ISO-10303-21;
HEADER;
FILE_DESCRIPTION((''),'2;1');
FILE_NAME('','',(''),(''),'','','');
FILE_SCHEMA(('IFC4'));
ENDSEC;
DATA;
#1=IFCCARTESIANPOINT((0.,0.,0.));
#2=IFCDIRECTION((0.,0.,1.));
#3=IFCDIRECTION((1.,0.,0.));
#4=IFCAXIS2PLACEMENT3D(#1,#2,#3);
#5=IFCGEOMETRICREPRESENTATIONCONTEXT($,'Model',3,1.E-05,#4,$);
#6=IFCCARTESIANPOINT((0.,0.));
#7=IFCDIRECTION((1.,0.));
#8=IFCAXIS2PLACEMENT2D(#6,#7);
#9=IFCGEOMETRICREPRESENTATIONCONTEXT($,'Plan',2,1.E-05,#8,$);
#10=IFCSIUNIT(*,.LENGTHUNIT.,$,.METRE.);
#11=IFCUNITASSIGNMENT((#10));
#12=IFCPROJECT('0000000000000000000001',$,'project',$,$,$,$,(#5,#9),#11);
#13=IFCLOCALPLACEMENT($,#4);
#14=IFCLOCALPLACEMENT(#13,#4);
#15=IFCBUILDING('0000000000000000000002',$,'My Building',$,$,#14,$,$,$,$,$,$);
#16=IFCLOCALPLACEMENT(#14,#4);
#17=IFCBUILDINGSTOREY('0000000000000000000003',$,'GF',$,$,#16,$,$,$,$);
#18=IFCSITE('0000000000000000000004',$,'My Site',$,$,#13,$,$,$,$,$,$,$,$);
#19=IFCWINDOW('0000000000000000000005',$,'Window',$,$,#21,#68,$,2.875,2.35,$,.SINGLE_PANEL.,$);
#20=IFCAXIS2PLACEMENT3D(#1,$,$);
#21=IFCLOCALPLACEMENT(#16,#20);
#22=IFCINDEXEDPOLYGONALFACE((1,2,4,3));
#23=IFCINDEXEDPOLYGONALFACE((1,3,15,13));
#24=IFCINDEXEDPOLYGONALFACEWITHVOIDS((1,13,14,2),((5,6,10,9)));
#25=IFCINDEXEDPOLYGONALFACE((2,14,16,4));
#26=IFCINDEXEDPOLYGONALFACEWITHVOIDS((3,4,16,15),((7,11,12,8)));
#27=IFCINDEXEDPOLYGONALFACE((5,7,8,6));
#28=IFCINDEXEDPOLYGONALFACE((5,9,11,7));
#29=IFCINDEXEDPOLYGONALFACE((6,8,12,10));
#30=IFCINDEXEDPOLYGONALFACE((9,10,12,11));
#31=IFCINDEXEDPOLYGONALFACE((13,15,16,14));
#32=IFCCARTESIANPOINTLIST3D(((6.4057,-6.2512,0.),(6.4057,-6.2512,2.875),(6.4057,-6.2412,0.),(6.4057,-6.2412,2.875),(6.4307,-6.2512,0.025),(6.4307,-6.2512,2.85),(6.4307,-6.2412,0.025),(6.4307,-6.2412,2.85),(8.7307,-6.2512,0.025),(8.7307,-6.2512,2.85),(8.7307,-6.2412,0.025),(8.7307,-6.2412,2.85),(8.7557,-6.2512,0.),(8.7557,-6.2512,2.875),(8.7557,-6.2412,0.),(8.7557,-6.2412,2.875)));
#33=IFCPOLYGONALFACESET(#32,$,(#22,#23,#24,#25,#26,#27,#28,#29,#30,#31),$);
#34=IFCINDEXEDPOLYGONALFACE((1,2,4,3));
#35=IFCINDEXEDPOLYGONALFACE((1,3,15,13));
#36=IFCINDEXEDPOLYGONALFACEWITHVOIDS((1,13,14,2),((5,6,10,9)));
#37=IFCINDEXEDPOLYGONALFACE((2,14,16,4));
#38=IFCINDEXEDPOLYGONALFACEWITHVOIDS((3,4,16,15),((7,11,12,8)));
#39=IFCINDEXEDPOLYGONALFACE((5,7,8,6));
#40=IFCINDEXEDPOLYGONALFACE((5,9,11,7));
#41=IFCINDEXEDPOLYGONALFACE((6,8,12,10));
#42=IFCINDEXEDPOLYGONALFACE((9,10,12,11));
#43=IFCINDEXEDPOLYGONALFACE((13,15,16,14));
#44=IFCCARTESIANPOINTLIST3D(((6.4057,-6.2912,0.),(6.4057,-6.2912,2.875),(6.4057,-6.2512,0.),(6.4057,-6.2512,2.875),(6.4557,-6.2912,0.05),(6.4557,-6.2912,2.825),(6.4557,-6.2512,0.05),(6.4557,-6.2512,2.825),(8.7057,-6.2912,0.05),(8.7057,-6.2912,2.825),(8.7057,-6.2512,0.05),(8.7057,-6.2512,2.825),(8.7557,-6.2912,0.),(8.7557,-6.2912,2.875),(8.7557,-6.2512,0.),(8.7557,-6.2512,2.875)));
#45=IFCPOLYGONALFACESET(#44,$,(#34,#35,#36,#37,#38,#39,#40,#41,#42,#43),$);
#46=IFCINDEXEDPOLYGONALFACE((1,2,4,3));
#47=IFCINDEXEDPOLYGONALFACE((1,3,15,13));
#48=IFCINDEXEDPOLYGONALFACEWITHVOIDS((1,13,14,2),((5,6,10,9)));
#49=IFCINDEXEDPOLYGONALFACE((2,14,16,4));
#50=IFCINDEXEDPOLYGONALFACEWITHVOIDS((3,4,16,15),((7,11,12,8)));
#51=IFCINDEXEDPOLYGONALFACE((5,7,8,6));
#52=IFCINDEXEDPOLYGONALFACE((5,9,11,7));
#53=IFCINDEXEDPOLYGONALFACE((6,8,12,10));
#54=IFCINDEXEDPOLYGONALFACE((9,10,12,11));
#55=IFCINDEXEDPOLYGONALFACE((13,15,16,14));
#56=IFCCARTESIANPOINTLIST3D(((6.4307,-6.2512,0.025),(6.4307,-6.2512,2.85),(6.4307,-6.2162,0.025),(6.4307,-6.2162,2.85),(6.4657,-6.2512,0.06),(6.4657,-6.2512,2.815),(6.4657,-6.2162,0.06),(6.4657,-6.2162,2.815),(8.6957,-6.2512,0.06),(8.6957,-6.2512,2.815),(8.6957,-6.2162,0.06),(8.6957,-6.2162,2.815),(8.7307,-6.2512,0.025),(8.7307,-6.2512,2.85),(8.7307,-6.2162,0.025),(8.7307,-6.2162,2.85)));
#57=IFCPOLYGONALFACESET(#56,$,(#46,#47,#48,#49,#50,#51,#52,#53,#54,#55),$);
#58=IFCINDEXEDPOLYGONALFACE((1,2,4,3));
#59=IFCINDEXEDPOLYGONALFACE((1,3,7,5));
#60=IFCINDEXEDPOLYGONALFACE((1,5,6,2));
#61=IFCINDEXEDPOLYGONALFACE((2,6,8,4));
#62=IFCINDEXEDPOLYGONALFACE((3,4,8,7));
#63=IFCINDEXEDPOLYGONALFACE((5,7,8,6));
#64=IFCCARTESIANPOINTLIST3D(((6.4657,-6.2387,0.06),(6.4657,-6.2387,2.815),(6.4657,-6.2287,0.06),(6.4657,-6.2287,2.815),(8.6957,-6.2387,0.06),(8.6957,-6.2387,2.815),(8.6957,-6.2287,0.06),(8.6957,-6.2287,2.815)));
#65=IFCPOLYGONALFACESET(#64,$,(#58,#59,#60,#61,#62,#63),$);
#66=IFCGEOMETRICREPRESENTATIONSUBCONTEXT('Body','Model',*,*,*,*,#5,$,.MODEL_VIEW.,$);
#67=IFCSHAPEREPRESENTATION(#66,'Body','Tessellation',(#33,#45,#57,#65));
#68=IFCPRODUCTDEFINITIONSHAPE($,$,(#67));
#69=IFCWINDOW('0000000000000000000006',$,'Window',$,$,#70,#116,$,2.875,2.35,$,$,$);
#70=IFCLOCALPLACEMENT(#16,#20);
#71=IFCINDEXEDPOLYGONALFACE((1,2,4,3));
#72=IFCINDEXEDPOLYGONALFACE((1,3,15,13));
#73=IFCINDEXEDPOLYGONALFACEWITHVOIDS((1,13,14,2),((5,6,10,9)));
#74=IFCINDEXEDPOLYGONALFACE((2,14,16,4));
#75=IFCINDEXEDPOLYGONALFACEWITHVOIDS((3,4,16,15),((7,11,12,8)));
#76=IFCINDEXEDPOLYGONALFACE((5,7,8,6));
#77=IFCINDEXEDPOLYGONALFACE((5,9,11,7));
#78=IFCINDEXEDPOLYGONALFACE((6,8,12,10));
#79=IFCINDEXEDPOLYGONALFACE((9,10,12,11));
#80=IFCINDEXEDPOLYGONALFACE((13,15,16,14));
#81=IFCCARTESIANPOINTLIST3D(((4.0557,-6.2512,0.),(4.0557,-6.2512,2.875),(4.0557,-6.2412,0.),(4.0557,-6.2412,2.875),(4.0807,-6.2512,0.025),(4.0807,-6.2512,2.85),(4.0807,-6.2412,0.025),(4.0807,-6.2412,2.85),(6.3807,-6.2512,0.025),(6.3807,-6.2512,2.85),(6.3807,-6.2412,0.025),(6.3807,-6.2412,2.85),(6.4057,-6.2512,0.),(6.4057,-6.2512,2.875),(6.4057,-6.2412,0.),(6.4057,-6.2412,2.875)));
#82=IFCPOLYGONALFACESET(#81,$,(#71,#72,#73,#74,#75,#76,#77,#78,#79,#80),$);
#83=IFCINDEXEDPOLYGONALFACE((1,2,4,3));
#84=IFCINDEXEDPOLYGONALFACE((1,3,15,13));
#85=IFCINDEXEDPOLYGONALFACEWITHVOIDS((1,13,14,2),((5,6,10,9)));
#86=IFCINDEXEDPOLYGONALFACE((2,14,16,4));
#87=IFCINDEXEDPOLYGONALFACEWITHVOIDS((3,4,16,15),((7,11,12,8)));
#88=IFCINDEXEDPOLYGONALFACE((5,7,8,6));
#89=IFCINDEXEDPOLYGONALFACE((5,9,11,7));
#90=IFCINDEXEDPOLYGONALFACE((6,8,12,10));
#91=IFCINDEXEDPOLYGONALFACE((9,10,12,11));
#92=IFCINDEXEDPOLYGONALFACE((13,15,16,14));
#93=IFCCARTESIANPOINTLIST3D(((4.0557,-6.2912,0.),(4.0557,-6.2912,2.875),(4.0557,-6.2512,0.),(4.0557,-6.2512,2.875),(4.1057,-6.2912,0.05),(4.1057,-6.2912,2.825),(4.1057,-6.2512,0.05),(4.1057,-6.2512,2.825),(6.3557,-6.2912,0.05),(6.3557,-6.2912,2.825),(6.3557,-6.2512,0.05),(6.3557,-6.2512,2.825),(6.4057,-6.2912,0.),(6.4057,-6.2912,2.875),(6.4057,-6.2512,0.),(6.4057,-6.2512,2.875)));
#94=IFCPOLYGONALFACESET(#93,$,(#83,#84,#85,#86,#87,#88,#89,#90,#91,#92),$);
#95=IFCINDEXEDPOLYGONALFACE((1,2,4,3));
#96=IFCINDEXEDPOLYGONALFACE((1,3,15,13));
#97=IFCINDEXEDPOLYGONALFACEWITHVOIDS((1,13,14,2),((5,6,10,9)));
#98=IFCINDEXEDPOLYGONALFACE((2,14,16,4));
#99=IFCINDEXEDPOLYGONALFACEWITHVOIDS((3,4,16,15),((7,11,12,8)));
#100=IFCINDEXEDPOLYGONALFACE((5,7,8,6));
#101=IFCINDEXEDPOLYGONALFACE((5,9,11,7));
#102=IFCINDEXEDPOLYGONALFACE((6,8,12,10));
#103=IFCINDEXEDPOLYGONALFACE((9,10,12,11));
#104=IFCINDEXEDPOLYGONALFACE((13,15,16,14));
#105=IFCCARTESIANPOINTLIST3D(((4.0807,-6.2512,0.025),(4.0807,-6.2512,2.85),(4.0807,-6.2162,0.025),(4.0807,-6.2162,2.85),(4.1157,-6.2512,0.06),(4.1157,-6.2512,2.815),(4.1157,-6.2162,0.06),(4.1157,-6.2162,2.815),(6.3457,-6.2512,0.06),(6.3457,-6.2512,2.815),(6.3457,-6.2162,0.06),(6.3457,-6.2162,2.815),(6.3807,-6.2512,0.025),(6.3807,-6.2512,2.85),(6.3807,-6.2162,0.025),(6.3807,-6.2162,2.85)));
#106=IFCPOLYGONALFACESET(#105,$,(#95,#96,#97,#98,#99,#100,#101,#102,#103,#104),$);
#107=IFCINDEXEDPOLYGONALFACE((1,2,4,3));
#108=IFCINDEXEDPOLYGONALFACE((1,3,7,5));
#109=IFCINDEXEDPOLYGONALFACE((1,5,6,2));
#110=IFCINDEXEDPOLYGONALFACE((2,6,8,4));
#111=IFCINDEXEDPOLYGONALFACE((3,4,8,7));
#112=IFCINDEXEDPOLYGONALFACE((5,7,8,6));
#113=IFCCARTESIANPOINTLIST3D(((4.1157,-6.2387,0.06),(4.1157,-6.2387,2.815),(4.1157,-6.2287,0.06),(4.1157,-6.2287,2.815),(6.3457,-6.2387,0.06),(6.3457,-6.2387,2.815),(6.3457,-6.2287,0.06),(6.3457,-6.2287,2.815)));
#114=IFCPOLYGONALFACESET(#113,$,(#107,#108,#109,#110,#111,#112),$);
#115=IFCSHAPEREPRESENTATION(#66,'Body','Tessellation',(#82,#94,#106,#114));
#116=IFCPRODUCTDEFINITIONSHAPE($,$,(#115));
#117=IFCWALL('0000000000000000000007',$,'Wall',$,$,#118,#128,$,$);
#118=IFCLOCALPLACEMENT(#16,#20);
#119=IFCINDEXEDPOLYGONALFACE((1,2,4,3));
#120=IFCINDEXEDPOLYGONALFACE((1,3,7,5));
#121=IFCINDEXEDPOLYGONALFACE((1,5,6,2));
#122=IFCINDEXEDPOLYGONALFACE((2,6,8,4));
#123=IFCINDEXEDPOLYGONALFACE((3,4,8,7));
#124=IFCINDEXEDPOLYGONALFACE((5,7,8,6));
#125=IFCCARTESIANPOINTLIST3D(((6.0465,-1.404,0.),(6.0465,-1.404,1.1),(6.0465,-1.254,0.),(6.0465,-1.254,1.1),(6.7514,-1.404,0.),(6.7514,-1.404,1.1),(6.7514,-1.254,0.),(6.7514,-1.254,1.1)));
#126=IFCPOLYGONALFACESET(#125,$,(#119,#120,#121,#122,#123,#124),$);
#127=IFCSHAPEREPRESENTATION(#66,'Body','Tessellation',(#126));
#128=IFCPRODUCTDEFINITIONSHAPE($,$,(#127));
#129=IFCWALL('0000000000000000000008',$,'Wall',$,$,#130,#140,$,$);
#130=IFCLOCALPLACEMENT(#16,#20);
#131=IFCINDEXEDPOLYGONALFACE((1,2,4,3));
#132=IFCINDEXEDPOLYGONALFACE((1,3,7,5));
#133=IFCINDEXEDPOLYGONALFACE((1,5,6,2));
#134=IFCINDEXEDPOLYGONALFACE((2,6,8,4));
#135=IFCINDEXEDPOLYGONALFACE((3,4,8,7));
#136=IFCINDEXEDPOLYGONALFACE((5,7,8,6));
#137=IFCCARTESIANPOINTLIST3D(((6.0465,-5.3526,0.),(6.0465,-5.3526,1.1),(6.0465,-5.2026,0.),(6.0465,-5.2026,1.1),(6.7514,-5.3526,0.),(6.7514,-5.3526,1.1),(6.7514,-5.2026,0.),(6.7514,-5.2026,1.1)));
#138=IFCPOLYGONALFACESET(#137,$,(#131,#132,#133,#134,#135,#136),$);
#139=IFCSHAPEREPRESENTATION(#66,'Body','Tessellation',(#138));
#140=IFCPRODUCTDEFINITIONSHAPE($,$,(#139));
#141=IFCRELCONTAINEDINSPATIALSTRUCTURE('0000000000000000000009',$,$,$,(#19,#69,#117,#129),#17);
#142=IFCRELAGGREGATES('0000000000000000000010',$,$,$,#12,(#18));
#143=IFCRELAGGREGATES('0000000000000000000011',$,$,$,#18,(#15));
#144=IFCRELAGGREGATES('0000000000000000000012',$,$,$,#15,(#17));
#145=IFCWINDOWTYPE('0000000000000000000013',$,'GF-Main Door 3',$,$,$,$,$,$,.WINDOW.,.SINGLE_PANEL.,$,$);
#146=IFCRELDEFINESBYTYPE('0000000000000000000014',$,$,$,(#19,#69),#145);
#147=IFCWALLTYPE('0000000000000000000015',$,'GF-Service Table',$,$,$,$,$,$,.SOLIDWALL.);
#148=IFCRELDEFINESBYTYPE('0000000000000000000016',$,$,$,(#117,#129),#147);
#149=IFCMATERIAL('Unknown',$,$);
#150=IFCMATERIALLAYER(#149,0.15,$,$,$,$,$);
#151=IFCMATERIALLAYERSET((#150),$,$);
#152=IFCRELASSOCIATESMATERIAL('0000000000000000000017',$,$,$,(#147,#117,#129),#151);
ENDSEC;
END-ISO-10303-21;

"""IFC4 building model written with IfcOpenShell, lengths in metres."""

from ifc_helpers import new_model, entity, si_unit, frame, origin_with_axes, origin_2d_with_axis, place, context, subcontext, project, spatial, line, indexed_curve, outline, extrude, shape, source, transform, mapped, material, layer, layer_set, layer_usage, type_object, type_shapes, element, save


model = new_model("IFC4")

# Units and contexts
model_context = context("Model", 3, precision=1e-05, world=origin_with_axes())
plan_context = context("Plan", 2, precision=1e-05, world=origin_2d_with_axis())
body_context_1 = subcontext(model_context, "Body", "Model", "MODEL_VIEW")
body_context_2 = subcontext(plan_context, "Body", "Plan", "PLAN_VIEW")
ifc_project = project(units=[si_unit("LENGTHUNIT", "METRE")], contexts=[model_context, plan_context])

# Site, building, storey
site_placement = place(None, origin_with_axes())
site = spatial("IfcSite", under=ifc_project, at=site_placement, Name="My Site")
building_placement = place(site_placement, origin_with_axes())
building = spatial("IfcBuilding", under=site, at=building_placement, Name="My Building")
storey_placement = place(building_placement, origin_with_axes())
storey = spatial("IfcBuildingStorey", under=building, at=storey_placement, Name="GF")

# Shared definitions
ifc_material = material(Name="Unknown")

# Windows
window_type = type_object("IfcWindowType", Name="GF-Main Door 3", PartitioningType="SINGLE_PANEL", PredefinedType="WINDOW")
shared_shape_1 = source(origin_with_axes(), body_context_1, "Body", "SweptSolid", [
    extrude(outline(indexed_curve([(0.0, 0.0), (2.35, 0.0), (2.35, 2.875), (0.0, 2.875)], segments=[line(1, 2, 3, 4, 1)]), holes=[indexed_curve([(0.025, 0.025), (2.325, 0.025), (2.325, 2.85), (0.025, 2.85)], segments=[line(1, 2, 3, 4, 1)])]), frame((0.0, 0.09, 0.0), z_axis=(0.0, -1.0, 0.0), x_axis=(1.0, 0.0, 0.0)), (0.0, 0.0, -1.0), 0.01),
    extrude(outline(indexed_curve([(0.0, 0.0), (2.35, 0.0), (2.35, 2.875), (0.0, 2.875)], segments=[line(1, 2, 3, 4, 1)]), holes=[indexed_curve([(0.05, 0.05), (2.3, 0.05), (2.3, 2.825), (0.05, 2.825)], segments=[line(1, 2, 3, 4, 1)])]), frame((0.0, 0.05, 0.0), z_axis=(0.0, -1.0, 0.0), x_axis=(1.0, 0.0, 0.0)), (0.0, 0.0, -1.0), 0.04),
    extrude(outline(indexed_curve([(0.0, 0.0), (2.3, 0.0), (2.3, 2.825), (0.0, 2.825)], segments=[line(1, 2, 3, 4, 1)]), holes=[indexed_curve([(0.035, 0.035), (2.265, 0.035), (2.265, 2.79), (0.035, 2.79)], segments=[line(1, 2, 3, 4, 1)])]), frame((0.025, 0.09, 0.025), z_axis=(0.0, -1.0, 0.0), x_axis=(1.0, 0.0, 0.0)), (0.0, 0.0, -1.0), 0.035),
    extrude(outline(indexed_curve([(0.035, 0.035), (2.265, 0.035), (2.265, 2.79), (0.035, 2.79)], segments=[line(1, 2, 3, 4, 1)])), frame((0.025, 0.1025, 0.025), z_axis=(0.0, -1.0, 0.0), x_axis=(1.0, 0.0, 0.0)), (0.0, 0.0, -1.0), 0.01),
])
shared_shape_2 = source(origin_with_axes(), body_context_2, "Body", "Curve2D", [
    entity("IfcIndexedPolyCurve", entity("IfcCartesianPointList2D", [[0.05, 0.05], [2.3, 0.05]])),
    entity("IfcIndexedPolyCurve", entity("IfcCartesianPointList2D", [[0.0, 0.1], [0.025, 0.1], [0.025, 0.09], [0.05, 0.09], [0.05, 0.05], [0.0, 0.05]]), [entity("IfcLineIndex", [1, 2, 3, 4, 5, 6, 1])]),
    entity("IfcIndexedPolyCurve", entity("IfcCartesianPointList2D", [[2.35, 0.1], [2.325, 0.1], [2.325, 0.09], [2.3, 0.09], [2.3, 0.05], [2.35, 0.05]]), [entity("IfcLineIndex", [1, 2, 3, 4, 5, 6, 1])]),
    entity("IfcIndexedPolyCurve", entity("IfcCartesianPointList2D", [[0.025, 0.09], [0.06, 0.09], [0.06, 0.125], [0.025, 0.125]]), [entity("IfcLineIndex", [1, 2, 3, 4, 1])]),
    entity("IfcIndexedPolyCurve", entity("IfcCartesianPointList2D", [[2.325, 0.09], [2.29, 0.09], [2.29, 0.125], [2.325, 0.125]]), [entity("IfcLineIndex", [1, 2, 3, 4, 1])]),
    entity("IfcIndexedPolyCurve", entity("IfcCartesianPointList2D", [[0.06, 0.09], [2.29, 0.09]])),
    entity("IfcIndexedPolyCurve", entity("IfcCartesianPointList2D", [[0.06, 0.125], [2.29, 0.125]])),
    entity("IfcIndexedPolyCurve", entity("IfcCartesianPointList2D", [[0.06, 0.1075], [2.29, 0.1075]])),
])
type_shapes(window_type, [shared_shape_1, shared_shape_2])
window_1_placement = place(storey_placement, frame((6.4057, -6.3412, 0.0), z_axis=(0.0, 0.0, 1.0), x_axis=(1.0, 0.0, 0.0)))
element("IfcWindow", 1, at=window_1_placement, inside=storey, type_object=window_type, Name="Window", OverallHeight=2.875, OverallWidth=2.35, PartitioningType="SINGLE_PANEL", shapes=[
    shape(body_context_1, "Body", "MappedRepresentation", [mapped(shared_shape_1, transform((0.0, 0.0, 0.0), x_axis=(1.0, 0.0, 0.0), y_axis=(0.0, 1.0, 0.0), z_axis=(0.0, 0.0, 1.0), scale=1.0))]),
    shape(body_context_2, "Body", "MappedRepresentation", [mapped(shared_shape_2, transform((0.0, 0.0, 0.0), x_axis=(1.0, 0.0, 0.0), y_axis=(0.0, 1.0, 0.0), z_axis=(0.0, 0.0, 1.0), scale=1.0))]),
])
window_2_placement = place(storey_placement, frame((4.0557, -6.3412, 0.0), z_axis=(0.0, 0.0, 1.0), x_axis=(1.0, 0.0, 0.0)))
element("IfcWindow", 2, at=window_2_placement, inside=storey, type_object=window_type, Name="Window", OverallHeight=2.875, OverallWidth=2.35, shapes=[
    shape(body_context_1, "Body", "MappedRepresentation", [mapped(shared_shape_1, transform((0.0, 0.0, 0.0), x_axis=(1.0, 0.0, 0.0), y_axis=(0.0, 1.0, 0.0), z_axis=(0.0, 0.0, 1.0), scale=1.0))]),
    shape(body_context_2, "Body", "MappedRepresentation", [mapped(shared_shape_2, transform((0.0, 0.0, 0.0), x_axis=(1.0, 0.0, 0.0), y_axis=(0.0, 1.0, 0.0), z_axis=(0.0, 0.0, 1.0), scale=1.0))]),
])

# Walls
ifc_layer_1 = layer(ifc_material, 0.15)
ifc_layer_set_1 = layer_set([ifc_layer_1])
ifc_layer_usage_1 = layer_usage(ifc_layer_set_1, "AXIS2", "POSITIVE", 0.0)
wall_type_1 = type_object("IfcWallType", Name="GF-Service Table", PredefinedType="SOLIDWALL", material=ifc_layer_set_1)
wall_1_placement = place(storey_placement, frame((6.0465, -1.404, 0.0), z_axis=(0.0, 0.0, 1.0), x_axis=(1.0, 0.0, 0.0)))
element("IfcWall", 3, at=wall_1_placement, inside=storey, type_object=wall_type_1, material=ifc_layer_usage_1, Name="Wall", context=body_context_1, shape_type="SweptSolid", body=[
    extrude(outline(indexed_curve([(0.0, 0.0), (0.0, 0.15), (0.7049, 0.15), (0.7049, 0.0)], segments=[line(1, 2, 3, 4, 1)])), origin_with_axes(), (0.0, 0.0, 1.0), 1.1),
])
ifc_layer_usage_2 = layer_usage(ifc_layer_set_1, "AXIS2", "POSITIVE", 0.0)
wall_2_placement = place(storey_placement, frame((6.0465, -5.3526, 0.0), z_axis=(0.0, 0.0, 1.0), x_axis=(1.0, 0.0, 0.0)))
element("IfcWall", 4, at=wall_2_placement, inside=storey, type_object=wall_type_1, material=ifc_layer_usage_2, Name="Wall", context=body_context_1, shape_type="SweptSolid", body=[
    extrude(outline(indexed_curve([(0.0, 0.0), (0.0, 0.15), (0.7049, 0.15), (0.7049, 0.0)], segments=[line(1, 2, 3, 4, 1)])), origin_with_axes(), (0.0, 0.0, 1.0), 1.1),
])

save(model, "model.ifc")
